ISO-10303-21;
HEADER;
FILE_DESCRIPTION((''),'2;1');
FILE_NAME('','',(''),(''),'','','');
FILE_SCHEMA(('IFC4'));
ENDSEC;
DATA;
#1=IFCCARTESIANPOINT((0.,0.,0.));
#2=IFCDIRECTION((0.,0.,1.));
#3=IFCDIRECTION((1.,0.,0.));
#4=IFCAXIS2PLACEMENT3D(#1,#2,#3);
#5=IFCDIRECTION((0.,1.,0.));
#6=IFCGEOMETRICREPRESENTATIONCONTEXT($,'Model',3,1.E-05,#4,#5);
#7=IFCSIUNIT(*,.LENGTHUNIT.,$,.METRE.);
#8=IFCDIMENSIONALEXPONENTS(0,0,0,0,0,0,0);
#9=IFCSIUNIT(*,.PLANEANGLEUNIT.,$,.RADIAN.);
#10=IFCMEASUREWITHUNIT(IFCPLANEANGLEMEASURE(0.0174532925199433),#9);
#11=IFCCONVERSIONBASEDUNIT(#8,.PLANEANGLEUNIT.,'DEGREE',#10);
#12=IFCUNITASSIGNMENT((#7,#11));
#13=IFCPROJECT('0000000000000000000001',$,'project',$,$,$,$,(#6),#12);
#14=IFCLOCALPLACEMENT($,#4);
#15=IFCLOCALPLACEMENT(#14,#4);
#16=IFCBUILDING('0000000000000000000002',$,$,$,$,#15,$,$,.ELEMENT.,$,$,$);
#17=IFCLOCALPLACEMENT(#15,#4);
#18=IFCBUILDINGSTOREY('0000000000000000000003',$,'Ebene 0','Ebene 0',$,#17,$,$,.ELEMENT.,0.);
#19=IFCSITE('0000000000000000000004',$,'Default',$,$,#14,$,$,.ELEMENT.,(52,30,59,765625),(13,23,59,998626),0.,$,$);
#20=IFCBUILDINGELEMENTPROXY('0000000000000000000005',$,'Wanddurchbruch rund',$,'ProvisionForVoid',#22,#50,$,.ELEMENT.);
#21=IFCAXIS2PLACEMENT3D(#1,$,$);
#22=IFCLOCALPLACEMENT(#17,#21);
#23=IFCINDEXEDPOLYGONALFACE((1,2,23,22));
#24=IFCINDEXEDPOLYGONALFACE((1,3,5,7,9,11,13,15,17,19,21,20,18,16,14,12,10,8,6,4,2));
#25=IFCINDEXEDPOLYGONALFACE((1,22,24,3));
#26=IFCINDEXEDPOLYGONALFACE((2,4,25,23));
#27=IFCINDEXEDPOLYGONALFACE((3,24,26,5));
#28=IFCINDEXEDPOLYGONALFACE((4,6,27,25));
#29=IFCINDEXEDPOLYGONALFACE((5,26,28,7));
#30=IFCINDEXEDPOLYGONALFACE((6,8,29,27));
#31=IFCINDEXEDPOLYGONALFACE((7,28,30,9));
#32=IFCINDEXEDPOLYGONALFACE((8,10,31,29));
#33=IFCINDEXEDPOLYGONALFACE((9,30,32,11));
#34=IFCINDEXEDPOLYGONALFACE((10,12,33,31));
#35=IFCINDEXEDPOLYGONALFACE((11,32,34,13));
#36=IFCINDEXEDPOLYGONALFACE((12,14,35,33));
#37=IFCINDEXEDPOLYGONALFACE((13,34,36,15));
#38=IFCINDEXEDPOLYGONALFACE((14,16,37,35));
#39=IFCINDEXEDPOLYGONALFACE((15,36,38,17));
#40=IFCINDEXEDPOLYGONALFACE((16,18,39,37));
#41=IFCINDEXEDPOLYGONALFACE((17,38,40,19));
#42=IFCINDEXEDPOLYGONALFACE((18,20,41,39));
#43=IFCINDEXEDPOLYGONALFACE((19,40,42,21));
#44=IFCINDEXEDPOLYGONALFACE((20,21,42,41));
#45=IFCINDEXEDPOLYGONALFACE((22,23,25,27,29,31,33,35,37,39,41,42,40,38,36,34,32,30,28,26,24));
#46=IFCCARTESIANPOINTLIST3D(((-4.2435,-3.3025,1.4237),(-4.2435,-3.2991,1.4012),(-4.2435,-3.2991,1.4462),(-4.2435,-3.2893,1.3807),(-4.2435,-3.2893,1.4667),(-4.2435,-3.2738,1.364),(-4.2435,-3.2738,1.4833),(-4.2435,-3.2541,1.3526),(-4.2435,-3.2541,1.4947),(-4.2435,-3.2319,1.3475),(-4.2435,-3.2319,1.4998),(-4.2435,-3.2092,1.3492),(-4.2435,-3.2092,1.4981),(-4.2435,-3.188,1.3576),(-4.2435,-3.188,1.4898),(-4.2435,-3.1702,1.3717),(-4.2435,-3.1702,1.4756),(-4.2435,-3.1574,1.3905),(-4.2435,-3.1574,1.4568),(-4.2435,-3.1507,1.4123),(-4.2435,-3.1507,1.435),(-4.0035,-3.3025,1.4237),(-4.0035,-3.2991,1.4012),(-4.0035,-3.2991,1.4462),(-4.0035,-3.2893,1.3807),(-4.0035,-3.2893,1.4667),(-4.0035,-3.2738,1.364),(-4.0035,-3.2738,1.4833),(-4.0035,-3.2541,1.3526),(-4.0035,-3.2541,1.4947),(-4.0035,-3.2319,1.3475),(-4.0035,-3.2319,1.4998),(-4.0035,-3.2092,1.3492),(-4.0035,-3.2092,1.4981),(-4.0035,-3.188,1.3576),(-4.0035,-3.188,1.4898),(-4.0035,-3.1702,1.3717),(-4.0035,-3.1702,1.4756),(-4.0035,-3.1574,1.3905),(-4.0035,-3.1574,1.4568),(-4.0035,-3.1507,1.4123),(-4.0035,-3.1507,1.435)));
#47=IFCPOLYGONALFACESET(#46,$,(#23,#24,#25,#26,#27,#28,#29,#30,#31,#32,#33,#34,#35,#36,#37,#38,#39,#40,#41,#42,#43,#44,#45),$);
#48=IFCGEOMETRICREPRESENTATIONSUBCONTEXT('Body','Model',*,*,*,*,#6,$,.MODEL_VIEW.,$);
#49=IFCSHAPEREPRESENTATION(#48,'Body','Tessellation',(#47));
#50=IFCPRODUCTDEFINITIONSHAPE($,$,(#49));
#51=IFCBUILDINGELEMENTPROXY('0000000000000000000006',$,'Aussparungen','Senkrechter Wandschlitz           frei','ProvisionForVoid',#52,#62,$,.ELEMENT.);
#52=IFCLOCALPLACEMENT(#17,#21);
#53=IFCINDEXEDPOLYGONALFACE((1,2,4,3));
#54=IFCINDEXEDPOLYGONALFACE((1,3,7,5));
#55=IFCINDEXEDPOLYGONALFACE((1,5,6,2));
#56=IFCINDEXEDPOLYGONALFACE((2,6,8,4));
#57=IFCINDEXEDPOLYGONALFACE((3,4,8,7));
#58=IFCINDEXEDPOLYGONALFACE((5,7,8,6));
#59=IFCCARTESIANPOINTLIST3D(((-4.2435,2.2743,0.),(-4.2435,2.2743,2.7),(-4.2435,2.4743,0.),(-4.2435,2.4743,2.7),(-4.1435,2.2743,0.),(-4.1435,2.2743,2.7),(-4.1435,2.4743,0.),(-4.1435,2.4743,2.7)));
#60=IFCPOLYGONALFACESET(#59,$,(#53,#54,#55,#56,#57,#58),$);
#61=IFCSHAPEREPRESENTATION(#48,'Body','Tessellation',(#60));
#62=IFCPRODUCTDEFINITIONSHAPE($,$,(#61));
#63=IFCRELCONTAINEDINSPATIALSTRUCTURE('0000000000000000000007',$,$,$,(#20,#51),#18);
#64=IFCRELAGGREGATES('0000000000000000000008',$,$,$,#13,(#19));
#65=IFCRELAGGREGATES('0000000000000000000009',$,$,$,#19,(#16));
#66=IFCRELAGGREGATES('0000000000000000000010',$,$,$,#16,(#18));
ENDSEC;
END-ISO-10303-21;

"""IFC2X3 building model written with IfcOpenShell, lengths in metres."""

from ifc_helpers import new_model, entity, si_unit, converted_unit, direction, frame, origin_with_axes, origin_2d_with_axis, place, context, subcontext, project, spatial, rectangle, circle, extrude, source, transform, mapped, element, save


model = new_model("IFC2X3")

# Units and contexts
model_context = context("Model", 3, precision=1e-05, world=origin_with_axes(), true_north=direction((0.0, 1.0, 0.0)))
body_context = subcontext(model_context, "Body", "Model", "MODEL_VIEW")
ifc_project = project(units=[si_unit("LENGTHUNIT", "METRE"), converted_unit("PLANEANGLEUNIT", "DEGREE", entity("IfcPlaneAngleMeasure", 0.0174532925199433), si_unit("PLANEANGLEUNIT", "RADIAN"), dimensions=[0, 0, 0, 0, 0, 0, 0])], contexts=[model_context])

# Site, building, storey
site_placement = place(None, origin_with_axes())
site = spatial("IfcSite", under=ifc_project, at=site_placement, Name="Default", CompositionType="ELEMENT", RefLatitude=(52, 30, 59, 765625), RefLongitude=(13, 23, 59, 998626), RefElevation=0.0)
building_placement = place(site_placement, origin_with_axes())
building = spatial("IfcBuilding", under=site, at=building_placement, CompositionType="ELEMENT")
storey_placement = place(building_placement, origin_with_axes())
storey = spatial("IfcBuildingStorey", under=building, at=storey_placement, Name="Ebene 0", Description="Ebene 0", CompositionType="ELEMENT", Elevation=0.0)

# Building element proxies
shared_shape_1 = source(origin_with_axes(), body_context, "Body", "SweptSolid", [
    extrude(circle(Radius=0.0763, at=origin_2d_with_axis()), frame((0.0763, 0.0, -0.0763), z_axis=(0.0, -1.0, 0.0), x_axis=(1.0, 0.0, 0.0)), (0.0, 0.0, -1.0), 0.24),
])
proxy_1_placement = place(storey_placement, frame((-4.2435, -3.1499, 1.5), z_axis=(0.0, 0.0, 1.0), x_axis=(0.0, -1.0, 0.0)))
element("IfcBuildingElementProxy", 1, at=proxy_1_placement, inside=storey, Name="Wanddurchbruch rund", ObjectType="ProvisionForVoid", CompositionType="ELEMENT", context=body_context, shape_type="MappedRepresentation", body=[
    mapped(shared_shape_1, transform((0.0, 0.0, 0.0), x_axis=(1.0, 0.0, 0.0), y_axis=(0.0, 1.0, 0.0), z_axis=(0.0, 0.0, 1.0), scale=1.0)),
])
shared_shape_2 = source(origin_with_axes(), body_context, "Body", "SweptSolid", [
    extrude(rectangle(XDim=0.2, YDim=0.1, at=origin_2d_with_axis()), frame((0.1, 0.05, -2.7), z_axis=(0.0, 0.0, 1.0), x_axis=(1.0, 0.0, 0.0)), (0.0, 0.0, 1.0), 2.7),
])
proxy_2_placement = place(storey_placement, frame((-4.2435, 2.4743, 2.7), z_axis=(0.0, 0.0, 1.0), x_axis=(0.0, -1.0, 0.0)))
element("IfcBuildingElementProxy", 2, at=proxy_2_placement, inside=storey, Name="Aussparungen", Description="Senkrechter Wandschlitz           frei", ObjectType="ProvisionForVoid", CompositionType="ELEMENT", context=body_context, shape_type="MappedRepresentation", body=[
    mapped(shared_shape_2, transform((0.0, 0.0, 0.0), x_axis=(1.0, 0.0, 0.0), y_axis=(0.0, 1.0, 0.0), z_axis=(0.0, 0.0, 1.0), scale=1.0)),
])

save(model, "model.ifc")
